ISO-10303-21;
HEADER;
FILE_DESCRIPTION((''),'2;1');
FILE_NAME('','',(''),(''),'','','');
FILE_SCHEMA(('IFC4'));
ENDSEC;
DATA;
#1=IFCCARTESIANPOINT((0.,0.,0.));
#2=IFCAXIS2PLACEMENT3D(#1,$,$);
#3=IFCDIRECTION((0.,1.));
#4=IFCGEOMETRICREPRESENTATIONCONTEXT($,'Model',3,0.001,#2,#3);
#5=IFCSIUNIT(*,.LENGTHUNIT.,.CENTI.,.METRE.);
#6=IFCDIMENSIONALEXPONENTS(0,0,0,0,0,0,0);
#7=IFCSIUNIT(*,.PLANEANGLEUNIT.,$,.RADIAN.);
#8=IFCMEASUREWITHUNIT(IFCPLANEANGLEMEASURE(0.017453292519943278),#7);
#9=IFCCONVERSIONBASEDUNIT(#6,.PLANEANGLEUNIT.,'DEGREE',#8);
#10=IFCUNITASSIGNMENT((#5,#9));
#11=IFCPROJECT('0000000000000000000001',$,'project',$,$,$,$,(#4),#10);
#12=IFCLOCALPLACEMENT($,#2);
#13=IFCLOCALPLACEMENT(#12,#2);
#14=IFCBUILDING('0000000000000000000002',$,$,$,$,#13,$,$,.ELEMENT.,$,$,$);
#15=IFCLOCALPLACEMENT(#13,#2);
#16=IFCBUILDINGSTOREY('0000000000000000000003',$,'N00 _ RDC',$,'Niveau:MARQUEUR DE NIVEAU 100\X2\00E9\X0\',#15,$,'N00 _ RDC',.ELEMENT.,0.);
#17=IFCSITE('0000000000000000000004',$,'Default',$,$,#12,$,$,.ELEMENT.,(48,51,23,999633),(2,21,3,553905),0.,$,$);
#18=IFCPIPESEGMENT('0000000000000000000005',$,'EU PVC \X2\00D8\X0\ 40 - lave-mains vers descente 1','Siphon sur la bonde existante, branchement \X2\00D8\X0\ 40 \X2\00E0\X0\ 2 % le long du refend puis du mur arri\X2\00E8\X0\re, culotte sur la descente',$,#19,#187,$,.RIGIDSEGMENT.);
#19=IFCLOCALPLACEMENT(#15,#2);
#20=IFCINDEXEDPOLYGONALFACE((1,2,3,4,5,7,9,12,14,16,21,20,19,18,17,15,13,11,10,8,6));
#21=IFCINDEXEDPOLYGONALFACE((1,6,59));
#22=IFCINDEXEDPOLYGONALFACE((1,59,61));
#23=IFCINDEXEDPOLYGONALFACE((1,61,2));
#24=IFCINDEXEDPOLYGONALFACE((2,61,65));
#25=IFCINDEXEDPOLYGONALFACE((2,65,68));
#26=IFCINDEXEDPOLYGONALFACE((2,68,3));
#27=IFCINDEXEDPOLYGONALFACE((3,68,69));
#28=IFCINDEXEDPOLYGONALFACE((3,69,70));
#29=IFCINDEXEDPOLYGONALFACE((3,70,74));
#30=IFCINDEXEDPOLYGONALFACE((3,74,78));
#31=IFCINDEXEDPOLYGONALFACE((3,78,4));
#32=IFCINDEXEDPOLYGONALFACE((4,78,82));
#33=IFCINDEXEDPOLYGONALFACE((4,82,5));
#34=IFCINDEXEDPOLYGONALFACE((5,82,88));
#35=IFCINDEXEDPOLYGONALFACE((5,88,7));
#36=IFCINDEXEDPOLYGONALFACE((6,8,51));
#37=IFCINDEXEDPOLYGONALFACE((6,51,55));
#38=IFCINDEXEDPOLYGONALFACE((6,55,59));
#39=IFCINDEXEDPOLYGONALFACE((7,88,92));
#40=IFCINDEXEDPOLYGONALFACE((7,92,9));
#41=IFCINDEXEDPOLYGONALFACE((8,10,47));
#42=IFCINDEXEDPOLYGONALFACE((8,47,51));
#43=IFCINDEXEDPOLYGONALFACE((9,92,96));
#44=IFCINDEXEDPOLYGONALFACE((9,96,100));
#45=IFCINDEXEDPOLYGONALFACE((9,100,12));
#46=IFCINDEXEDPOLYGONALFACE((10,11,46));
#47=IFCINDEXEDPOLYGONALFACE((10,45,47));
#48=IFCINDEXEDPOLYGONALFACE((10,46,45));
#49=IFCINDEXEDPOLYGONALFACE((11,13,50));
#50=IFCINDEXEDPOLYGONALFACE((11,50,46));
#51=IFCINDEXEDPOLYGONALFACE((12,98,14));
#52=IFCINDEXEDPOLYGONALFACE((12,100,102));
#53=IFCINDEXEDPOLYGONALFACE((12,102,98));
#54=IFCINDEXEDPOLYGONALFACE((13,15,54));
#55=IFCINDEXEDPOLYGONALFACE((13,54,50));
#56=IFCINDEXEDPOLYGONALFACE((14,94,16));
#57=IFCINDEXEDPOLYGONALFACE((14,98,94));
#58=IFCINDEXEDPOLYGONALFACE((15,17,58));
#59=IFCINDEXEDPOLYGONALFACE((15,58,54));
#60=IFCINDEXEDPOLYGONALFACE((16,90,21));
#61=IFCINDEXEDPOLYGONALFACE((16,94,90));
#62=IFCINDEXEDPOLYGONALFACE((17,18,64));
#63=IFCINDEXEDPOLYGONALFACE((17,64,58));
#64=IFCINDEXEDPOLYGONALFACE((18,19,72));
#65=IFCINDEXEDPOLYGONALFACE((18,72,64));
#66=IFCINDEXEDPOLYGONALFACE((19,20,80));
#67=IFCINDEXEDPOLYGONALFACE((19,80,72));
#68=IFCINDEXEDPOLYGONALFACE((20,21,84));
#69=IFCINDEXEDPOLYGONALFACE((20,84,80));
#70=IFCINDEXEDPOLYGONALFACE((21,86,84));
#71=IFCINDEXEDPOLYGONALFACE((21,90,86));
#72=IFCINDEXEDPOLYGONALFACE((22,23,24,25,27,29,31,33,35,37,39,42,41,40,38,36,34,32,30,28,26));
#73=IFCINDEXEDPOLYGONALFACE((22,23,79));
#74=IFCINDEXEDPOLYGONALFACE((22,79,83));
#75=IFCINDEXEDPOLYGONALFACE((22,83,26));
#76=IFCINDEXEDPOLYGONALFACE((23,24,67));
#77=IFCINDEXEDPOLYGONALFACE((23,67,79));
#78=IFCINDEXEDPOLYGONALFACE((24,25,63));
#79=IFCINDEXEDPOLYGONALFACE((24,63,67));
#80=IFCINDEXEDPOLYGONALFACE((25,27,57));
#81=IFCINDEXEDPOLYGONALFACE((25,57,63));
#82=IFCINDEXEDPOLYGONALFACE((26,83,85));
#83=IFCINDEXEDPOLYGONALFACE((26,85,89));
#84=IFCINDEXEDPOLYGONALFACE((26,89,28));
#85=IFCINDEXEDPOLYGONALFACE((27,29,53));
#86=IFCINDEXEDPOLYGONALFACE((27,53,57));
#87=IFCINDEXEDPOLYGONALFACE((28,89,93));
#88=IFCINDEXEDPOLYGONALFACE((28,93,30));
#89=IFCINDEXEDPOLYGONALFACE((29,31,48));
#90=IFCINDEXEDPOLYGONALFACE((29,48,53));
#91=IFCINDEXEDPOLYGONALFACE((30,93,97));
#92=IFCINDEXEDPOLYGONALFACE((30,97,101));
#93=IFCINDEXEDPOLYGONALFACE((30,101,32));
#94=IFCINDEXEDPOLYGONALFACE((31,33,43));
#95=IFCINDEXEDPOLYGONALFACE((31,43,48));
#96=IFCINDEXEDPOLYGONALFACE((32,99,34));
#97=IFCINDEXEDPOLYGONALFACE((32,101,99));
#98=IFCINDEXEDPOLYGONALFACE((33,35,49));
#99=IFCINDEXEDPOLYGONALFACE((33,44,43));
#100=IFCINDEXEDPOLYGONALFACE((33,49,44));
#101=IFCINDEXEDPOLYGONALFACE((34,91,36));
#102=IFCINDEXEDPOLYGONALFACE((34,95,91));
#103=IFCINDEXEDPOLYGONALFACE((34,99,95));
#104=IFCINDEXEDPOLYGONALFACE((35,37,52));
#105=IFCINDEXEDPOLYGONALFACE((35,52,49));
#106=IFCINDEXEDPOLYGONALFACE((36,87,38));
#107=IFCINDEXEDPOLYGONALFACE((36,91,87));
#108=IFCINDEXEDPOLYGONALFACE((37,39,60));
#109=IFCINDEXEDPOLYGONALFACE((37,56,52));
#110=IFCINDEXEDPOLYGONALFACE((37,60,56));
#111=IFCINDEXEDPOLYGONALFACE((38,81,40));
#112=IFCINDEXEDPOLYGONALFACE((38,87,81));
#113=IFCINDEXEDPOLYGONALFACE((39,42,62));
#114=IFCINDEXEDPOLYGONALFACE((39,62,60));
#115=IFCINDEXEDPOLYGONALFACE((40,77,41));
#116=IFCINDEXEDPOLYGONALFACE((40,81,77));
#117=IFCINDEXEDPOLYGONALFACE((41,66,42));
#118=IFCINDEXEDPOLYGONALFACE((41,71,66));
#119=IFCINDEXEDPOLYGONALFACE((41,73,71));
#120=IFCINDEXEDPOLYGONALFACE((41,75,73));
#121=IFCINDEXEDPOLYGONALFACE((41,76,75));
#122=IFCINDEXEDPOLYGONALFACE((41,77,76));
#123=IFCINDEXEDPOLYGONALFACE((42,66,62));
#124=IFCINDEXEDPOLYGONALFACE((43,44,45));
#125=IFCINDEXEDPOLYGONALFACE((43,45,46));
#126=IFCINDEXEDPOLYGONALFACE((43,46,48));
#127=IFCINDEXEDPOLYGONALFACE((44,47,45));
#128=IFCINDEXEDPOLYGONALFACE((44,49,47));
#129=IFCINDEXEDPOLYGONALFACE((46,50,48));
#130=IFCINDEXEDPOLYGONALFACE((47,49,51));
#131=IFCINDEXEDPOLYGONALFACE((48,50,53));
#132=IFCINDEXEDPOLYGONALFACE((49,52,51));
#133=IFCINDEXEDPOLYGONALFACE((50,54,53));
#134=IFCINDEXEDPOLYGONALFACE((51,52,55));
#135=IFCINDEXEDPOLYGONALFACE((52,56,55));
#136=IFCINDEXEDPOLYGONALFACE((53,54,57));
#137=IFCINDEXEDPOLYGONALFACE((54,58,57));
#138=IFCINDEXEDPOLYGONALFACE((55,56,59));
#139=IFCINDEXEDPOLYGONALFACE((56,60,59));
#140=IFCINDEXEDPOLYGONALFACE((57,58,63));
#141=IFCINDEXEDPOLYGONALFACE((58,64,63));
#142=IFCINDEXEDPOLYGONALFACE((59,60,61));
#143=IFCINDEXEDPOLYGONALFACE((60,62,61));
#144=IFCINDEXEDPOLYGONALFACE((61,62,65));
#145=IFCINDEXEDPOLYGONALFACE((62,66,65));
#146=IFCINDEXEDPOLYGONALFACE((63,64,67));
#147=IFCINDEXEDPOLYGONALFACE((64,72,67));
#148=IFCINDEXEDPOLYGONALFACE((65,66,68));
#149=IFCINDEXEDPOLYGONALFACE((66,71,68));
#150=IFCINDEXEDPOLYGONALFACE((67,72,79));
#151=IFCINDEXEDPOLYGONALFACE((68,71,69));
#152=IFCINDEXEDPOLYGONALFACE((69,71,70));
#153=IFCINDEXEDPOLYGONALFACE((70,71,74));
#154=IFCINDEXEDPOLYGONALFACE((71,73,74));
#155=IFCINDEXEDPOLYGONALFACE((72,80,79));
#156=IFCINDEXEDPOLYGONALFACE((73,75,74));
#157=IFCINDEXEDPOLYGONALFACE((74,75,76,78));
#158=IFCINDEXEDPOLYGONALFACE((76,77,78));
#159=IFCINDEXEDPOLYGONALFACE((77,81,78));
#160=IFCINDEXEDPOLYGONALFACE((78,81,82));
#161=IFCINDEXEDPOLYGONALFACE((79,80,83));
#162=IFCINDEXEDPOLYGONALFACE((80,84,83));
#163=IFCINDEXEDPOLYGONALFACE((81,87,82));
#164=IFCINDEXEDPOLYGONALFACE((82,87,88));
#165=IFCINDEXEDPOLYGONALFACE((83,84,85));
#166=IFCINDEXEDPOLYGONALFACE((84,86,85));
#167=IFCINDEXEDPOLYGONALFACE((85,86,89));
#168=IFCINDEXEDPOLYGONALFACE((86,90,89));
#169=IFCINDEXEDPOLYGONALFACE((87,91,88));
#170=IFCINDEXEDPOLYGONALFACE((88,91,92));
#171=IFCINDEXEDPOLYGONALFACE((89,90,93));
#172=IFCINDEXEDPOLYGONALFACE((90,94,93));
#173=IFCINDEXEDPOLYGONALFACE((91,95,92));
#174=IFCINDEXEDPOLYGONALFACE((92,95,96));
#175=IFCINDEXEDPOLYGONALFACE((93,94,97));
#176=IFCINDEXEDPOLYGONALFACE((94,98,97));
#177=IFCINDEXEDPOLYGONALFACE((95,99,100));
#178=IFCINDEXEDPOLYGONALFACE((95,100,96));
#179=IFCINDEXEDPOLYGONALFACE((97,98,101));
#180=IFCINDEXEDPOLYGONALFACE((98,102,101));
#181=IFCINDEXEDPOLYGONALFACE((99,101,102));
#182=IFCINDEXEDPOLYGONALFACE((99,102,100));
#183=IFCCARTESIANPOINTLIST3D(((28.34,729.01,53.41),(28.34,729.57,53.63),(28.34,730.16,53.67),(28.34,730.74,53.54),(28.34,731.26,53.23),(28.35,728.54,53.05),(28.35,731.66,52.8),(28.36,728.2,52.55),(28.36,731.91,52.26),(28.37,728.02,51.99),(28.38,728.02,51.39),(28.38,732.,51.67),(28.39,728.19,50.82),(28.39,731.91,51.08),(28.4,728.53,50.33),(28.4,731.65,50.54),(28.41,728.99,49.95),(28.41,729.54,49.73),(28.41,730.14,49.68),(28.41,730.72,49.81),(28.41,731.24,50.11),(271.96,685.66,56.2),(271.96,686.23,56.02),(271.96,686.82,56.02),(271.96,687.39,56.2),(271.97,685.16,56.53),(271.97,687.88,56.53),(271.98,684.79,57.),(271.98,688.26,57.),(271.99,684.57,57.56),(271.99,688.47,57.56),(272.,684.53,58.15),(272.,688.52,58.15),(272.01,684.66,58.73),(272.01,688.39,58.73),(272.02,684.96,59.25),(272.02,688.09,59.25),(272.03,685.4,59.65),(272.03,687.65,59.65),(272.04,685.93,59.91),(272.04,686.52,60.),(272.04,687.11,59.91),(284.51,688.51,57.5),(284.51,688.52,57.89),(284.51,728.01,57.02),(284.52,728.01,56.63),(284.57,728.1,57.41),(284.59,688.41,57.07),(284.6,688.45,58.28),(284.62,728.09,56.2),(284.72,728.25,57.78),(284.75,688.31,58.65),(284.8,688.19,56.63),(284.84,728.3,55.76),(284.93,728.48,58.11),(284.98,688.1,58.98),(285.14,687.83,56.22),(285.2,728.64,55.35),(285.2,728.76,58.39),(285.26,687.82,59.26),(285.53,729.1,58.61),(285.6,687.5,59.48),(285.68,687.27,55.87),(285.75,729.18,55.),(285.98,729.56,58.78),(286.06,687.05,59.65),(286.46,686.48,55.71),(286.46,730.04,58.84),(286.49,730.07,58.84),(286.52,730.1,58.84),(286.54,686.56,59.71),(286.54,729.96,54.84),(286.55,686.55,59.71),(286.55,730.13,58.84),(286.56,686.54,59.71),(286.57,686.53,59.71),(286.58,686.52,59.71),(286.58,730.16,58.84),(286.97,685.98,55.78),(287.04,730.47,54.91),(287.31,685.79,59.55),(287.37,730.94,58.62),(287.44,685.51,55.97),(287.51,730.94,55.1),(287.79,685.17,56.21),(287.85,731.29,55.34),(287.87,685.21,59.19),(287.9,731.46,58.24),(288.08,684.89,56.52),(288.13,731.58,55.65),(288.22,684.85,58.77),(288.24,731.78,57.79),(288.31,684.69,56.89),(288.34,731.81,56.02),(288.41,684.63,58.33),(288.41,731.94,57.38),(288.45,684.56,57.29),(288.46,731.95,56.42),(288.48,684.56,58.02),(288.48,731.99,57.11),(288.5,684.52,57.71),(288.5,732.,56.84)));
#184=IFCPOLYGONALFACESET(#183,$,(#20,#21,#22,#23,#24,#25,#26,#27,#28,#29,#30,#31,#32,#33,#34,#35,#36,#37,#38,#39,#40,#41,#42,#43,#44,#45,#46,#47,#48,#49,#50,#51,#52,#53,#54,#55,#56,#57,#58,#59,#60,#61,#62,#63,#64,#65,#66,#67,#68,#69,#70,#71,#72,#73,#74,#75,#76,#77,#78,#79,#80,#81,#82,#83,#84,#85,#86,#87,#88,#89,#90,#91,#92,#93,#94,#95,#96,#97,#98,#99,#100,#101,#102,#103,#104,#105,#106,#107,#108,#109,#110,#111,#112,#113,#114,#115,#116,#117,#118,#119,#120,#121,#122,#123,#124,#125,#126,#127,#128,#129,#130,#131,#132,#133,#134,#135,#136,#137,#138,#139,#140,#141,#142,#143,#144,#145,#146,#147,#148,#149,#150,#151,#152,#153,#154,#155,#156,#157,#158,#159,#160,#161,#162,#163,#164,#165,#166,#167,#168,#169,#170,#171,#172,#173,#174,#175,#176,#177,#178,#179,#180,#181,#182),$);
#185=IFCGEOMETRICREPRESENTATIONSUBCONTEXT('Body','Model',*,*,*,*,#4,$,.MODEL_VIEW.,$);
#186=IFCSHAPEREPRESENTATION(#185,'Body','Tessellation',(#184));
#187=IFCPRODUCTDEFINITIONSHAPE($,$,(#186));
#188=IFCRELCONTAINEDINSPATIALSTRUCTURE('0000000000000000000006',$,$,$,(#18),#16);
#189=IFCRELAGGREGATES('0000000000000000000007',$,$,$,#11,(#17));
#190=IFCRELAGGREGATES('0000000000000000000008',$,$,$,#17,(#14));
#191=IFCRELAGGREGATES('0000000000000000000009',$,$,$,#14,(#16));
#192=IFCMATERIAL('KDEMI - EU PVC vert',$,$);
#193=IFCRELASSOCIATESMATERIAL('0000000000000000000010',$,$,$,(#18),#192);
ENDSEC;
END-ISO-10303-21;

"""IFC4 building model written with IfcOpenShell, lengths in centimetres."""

from ifc_helpers import new_model, entity, si_unit, converted_unit, direction, origin, origin_with_axes, place, context, subcontext, project, spatial, material, element, save


model = new_model("IFC4")

# Units and contexts
model_context = context("Model", 3, precision=0.001, world=origin(), true_north=direction((0.0, 1.0)))
body_context = subcontext(model_context, "Body", "Model", "MODEL_VIEW")
ifc_project = project(units=[si_unit("LENGTHUNIT", "METRE", prefix="CENTI"), converted_unit("PLANEANGLEUNIT", "DEGREE", entity("IfcPlaneAngleMeasure", 0.017453292519943278), si_unit("PLANEANGLEUNIT", "RADIAN"), dimensions=[0, 0, 0, 0, 0, 0, 0])], contexts=[model_context])

# Site, building, storey
site_placement = place(None, origin())
site = spatial("IfcSite", under=ifc_project, at=site_placement, Name="Default", CompositionType="ELEMENT", RefLatitude=(48, 51, 23, 999633), RefLongitude=(2, 21, 3, 553905), RefElevation=0.0)
building_placement = place(site_placement, origin())
building = spatial("IfcBuilding", under=site, at=building_placement, CompositionType="ELEMENT")
storey_placement = place(building_placement, origin())
storey = spatial("IfcBuildingStorey", under=building, at=storey_placement, Name="N00 _ RDC", ObjectType="Niveau:MARQUEUR DE NIVEAU 100é", LongName="N00 _ RDC", CompositionType="ELEMENT", Elevation=0.0)

# Pipe segment
ifc_material_1 = material(Name="KDEMI - EU PVC vert")
pipe_segment_1_placement = place(storey_placement, origin_with_axes())
element("IfcPipeSegment", 1, at=pipe_segment_1_placement, inside=storey, material=ifc_material_1, Name="EU PVC Ø 40 - lave-mains vers descente 1", Description="Siphon sur la bonde existante, branchement Ø 40 à 2 % le long du refend puis du mur arrière, culotte sur la descente", PredefinedType="RIGIDSEGMENT", context=body_context, shape_type="AdvancedSweptSolid", body=[
    entity("IfcSweptDiskSolid", entity("IfcPolyline", [entity("IfcCartesianPoint", [272.0, 686.52, 58.0]), entity("IfcCartesianPoint", [286.5, 686.52, 57.71]), entity("IfcCartesianPoint", [286.5, 730.0, 56.84]), entity("IfcCartesianPoint", [28.37, 730.0, 51.68])]), 2.0),
])

save(model, "model.ifc")
